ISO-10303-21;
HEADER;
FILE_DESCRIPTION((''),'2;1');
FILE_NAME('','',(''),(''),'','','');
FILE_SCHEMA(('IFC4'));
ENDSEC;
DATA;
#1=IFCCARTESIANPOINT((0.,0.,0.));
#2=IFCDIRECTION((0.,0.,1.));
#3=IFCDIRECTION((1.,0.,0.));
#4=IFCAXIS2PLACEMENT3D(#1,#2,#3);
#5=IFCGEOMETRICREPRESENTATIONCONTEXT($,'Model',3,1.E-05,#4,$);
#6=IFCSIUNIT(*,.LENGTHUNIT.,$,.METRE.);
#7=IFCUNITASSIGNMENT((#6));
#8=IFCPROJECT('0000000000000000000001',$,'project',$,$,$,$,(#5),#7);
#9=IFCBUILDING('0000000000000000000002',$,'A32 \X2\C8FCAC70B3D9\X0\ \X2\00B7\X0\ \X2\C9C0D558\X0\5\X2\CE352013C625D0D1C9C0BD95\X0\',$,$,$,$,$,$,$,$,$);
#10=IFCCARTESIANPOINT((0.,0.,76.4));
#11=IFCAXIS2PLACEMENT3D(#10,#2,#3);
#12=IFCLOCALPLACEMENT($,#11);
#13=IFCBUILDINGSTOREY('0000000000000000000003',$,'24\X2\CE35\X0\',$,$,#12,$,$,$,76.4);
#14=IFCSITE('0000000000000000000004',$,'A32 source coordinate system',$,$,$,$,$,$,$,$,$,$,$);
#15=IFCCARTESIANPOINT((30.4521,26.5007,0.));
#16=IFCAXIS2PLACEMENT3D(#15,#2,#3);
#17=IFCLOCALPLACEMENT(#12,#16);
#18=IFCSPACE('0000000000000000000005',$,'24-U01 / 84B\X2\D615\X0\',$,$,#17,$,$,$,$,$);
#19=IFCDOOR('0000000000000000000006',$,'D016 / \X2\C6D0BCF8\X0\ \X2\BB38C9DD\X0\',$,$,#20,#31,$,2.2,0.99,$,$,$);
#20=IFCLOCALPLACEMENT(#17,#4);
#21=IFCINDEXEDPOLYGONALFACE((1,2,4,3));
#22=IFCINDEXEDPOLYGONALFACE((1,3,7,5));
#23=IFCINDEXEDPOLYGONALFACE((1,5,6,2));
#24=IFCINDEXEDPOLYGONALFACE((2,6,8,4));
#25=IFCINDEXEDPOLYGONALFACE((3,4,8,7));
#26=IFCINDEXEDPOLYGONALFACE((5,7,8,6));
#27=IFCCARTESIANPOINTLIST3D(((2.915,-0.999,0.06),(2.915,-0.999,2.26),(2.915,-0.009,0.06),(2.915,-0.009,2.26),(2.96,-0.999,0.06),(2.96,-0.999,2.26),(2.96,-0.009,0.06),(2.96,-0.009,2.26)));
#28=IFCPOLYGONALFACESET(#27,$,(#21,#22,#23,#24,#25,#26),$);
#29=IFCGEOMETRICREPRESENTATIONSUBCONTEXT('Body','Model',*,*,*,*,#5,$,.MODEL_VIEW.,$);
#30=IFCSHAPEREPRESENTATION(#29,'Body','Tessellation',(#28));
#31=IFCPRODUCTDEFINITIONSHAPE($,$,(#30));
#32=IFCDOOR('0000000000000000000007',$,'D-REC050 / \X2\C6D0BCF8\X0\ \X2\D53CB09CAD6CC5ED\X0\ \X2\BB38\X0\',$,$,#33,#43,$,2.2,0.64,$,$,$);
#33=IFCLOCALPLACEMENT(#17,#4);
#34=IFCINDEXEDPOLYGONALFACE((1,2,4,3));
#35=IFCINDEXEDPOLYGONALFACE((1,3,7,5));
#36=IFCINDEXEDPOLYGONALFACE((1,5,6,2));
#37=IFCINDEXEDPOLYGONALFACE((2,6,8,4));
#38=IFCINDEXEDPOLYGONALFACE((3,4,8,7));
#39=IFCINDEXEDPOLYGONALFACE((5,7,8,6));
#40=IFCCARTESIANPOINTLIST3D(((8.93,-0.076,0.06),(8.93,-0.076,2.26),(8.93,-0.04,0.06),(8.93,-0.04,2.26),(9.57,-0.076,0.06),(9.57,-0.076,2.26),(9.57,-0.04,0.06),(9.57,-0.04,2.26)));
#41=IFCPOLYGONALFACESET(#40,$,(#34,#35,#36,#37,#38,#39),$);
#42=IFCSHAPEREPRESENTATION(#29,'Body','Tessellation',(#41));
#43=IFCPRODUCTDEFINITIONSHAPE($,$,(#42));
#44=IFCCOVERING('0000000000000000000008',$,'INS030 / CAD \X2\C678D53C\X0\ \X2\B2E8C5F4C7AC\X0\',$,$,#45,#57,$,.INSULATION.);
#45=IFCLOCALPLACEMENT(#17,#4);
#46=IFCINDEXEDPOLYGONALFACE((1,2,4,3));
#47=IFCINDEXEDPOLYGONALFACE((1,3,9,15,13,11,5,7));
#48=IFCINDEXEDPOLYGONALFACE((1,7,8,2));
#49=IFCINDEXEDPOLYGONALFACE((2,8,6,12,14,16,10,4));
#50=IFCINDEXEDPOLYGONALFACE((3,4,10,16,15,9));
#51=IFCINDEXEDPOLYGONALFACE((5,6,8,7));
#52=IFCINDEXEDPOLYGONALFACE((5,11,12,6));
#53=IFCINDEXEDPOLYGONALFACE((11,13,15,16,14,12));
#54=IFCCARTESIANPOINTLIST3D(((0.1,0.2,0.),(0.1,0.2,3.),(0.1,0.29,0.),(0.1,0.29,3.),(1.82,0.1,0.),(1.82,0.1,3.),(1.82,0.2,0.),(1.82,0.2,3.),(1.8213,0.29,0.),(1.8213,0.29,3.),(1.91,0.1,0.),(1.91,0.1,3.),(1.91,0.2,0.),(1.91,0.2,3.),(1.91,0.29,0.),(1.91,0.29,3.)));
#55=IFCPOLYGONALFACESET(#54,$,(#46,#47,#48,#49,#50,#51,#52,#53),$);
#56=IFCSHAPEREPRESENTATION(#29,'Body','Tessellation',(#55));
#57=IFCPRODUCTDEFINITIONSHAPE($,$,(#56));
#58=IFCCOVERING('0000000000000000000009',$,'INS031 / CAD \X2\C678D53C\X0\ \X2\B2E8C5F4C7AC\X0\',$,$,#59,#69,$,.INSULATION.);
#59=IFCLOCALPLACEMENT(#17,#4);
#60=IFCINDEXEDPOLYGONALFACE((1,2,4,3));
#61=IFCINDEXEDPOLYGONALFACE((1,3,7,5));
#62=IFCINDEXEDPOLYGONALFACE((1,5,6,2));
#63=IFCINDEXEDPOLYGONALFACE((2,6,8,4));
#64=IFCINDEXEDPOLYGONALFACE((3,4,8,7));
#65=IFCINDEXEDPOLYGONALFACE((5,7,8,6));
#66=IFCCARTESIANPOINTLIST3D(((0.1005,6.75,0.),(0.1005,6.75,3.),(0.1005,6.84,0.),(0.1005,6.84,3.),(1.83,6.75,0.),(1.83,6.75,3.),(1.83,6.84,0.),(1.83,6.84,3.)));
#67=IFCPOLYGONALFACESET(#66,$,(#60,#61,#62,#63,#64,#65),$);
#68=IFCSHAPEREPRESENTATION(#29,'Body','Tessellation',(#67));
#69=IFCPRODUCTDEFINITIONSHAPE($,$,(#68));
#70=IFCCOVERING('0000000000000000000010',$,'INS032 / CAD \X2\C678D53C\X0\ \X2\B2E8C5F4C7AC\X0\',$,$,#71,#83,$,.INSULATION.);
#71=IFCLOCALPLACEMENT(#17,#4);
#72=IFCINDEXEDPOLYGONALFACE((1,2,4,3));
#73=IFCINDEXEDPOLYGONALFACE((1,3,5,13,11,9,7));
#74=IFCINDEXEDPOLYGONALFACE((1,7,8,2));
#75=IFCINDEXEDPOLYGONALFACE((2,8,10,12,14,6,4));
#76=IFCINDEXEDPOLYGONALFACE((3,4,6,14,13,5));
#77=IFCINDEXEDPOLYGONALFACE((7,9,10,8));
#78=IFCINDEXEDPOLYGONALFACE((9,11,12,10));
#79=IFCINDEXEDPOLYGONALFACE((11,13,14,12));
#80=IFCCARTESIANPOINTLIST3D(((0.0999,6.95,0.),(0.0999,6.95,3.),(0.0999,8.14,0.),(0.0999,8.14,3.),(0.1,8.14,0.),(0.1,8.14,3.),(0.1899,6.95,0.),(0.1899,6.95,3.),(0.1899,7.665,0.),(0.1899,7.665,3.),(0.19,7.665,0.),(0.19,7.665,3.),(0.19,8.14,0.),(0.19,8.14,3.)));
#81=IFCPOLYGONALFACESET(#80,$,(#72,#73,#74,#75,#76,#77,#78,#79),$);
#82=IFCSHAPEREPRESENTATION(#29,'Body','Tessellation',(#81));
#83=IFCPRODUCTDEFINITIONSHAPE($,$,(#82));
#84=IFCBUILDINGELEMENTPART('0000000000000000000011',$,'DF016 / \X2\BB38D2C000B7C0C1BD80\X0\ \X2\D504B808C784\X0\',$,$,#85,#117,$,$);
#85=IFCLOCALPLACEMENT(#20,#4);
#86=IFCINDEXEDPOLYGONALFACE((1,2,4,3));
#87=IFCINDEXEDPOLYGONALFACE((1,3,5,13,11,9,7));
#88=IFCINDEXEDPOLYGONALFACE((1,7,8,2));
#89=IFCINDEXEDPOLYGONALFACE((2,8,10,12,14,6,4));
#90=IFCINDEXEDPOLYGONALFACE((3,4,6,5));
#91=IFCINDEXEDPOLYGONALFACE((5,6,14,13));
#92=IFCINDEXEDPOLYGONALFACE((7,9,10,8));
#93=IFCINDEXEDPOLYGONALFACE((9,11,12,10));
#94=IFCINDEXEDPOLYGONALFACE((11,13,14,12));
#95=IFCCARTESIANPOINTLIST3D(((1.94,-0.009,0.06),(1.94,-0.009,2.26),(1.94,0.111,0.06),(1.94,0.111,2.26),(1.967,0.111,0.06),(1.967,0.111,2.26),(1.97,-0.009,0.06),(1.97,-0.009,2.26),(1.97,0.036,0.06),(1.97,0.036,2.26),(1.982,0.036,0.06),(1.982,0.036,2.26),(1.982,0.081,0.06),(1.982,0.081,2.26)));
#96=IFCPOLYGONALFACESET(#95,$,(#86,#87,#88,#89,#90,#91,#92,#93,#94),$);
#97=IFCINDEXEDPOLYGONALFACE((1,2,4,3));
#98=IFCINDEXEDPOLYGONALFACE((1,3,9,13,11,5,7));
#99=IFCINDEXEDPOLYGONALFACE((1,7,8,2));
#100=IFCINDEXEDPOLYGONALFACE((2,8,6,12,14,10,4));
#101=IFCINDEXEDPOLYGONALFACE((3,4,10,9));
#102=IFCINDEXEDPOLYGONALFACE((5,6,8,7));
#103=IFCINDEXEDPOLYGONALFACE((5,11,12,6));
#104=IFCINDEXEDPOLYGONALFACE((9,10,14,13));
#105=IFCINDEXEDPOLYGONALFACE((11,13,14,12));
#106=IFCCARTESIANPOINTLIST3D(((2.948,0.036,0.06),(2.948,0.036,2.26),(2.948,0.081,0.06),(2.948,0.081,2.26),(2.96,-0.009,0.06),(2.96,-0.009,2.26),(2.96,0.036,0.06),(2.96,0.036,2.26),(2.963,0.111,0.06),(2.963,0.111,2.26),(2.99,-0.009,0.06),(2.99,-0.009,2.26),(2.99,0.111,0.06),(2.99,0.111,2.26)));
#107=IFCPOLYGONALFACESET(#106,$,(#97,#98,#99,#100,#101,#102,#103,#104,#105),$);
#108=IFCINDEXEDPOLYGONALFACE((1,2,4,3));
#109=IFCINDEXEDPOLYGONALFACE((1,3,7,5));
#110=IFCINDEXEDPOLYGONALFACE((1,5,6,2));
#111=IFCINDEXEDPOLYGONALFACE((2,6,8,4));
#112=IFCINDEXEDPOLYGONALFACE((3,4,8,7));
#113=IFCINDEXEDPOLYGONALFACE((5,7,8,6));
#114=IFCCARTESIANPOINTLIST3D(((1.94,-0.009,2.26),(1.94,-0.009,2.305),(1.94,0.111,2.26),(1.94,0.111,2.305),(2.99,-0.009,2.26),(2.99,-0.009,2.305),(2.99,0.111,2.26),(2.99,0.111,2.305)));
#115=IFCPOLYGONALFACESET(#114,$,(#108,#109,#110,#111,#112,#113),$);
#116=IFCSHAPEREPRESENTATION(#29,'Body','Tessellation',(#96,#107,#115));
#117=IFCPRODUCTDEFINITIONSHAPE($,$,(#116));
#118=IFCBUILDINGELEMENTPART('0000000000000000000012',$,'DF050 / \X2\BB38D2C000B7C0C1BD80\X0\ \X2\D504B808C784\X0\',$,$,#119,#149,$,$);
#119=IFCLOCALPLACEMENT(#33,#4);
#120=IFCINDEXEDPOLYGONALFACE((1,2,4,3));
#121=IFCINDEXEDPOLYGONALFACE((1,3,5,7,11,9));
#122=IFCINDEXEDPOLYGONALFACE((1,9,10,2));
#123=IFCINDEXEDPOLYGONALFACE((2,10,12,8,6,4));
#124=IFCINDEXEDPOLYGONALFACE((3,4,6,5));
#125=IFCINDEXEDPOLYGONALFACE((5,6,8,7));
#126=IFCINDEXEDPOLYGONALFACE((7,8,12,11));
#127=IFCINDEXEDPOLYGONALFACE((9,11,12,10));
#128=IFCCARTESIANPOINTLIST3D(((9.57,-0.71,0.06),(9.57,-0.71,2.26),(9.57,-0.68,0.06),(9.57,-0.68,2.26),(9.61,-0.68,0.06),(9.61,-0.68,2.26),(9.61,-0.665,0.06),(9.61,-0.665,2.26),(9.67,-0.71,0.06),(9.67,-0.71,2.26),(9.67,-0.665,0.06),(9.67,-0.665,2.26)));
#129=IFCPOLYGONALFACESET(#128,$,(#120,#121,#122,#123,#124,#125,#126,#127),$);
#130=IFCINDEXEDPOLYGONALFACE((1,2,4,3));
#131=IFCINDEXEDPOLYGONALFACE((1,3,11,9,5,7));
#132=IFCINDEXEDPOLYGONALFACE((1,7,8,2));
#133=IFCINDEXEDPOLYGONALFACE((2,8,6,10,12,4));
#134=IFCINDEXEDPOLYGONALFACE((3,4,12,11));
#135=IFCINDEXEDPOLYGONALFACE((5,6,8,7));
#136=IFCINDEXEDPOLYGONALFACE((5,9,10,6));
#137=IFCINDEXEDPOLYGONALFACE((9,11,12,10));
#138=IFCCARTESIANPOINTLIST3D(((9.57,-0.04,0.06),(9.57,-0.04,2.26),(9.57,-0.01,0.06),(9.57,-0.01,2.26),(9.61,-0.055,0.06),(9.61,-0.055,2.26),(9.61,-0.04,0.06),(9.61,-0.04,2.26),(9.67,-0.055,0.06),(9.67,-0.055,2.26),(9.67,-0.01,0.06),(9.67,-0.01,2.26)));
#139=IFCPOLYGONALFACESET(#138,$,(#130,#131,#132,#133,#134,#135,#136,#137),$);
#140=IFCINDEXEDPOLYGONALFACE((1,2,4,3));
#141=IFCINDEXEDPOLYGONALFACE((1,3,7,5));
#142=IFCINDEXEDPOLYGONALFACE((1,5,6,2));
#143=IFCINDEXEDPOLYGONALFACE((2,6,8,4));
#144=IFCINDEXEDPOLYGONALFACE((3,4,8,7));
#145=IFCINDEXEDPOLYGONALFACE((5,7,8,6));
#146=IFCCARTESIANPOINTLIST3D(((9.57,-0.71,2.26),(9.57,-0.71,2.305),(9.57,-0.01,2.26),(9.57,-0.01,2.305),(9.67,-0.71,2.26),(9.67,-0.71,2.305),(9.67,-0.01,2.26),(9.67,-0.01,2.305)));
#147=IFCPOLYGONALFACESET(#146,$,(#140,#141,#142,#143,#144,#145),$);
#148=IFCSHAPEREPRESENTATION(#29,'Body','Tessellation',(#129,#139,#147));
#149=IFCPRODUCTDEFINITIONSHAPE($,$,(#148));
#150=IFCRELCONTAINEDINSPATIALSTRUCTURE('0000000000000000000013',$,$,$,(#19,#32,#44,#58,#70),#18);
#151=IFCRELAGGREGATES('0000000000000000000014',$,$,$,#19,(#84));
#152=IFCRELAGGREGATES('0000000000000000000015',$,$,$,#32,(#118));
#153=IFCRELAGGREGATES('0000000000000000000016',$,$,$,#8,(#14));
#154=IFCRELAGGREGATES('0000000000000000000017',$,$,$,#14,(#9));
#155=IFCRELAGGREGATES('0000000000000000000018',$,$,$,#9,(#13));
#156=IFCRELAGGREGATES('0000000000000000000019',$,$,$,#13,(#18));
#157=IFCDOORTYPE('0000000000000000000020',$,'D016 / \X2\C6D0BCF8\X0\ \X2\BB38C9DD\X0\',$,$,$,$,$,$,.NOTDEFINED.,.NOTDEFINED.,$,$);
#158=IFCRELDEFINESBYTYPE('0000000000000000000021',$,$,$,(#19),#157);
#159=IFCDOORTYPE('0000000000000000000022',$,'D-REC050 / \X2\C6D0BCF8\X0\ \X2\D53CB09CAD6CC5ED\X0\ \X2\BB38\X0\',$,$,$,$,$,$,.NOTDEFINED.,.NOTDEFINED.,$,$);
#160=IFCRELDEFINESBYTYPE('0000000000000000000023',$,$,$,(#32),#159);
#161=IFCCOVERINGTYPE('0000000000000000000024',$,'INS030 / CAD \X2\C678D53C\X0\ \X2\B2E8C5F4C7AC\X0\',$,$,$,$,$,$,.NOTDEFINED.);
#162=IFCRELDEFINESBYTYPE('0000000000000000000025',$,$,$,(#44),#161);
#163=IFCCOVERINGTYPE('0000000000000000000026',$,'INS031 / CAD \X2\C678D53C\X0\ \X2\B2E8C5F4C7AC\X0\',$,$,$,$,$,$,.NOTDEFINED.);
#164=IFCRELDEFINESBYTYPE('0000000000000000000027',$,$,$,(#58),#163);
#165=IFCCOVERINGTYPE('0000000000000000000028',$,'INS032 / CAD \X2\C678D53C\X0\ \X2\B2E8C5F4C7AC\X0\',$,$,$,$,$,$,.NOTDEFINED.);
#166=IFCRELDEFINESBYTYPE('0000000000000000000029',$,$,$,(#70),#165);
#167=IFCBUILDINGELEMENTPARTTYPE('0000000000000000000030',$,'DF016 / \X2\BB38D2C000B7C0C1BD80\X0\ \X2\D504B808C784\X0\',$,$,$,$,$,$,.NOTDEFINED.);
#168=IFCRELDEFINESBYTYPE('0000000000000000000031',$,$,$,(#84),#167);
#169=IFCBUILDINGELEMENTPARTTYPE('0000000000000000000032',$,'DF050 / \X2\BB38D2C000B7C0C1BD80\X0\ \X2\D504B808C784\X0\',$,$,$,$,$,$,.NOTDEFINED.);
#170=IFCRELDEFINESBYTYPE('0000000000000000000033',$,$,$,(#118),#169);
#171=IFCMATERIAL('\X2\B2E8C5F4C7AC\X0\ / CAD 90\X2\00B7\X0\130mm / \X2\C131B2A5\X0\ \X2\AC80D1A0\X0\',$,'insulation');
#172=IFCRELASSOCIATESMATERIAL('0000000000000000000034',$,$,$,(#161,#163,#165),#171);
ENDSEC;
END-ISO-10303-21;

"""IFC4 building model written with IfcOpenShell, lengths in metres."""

from ifc_helpers import new_model, si_unit, frame, origin, origin_with_axes, place, context, subcontext, project, spatial, polyline, outline, extrude, source, transform, mapped, material, type_object, type_shapes, element, aggregate, save


model = new_model("IFC4")

# Units and contexts
model_context = context("Model", 3, precision=1e-05, world=origin_with_axes())
body_context = subcontext(model_context, "Body", "Model", "MODEL_VIEW")
ifc_project = project(units=[si_unit("LENGTHUNIT", "METRE")], contexts=[model_context])

# Site, building, storey, space
storey_placement = place(None, frame((0.0, 0.0, 76.4), z_axis=(0.0, 0.0, 1.0), x_axis=(1.0, 0.0, 0.0)))
space_placement = place(storey_placement, frame((30.4521, 26.5007, 0.0), z_axis=(0.0, 0.0, 1.0), x_axis=(1.0, 0.0, 0.0)))
site = spatial("IfcSite", under=ifc_project, Name="A32 source coordinate system")
building = spatial("IfcBuilding", under=site, Name="A32 주거동 · 지하5층–옥탑지붕")
storey = spatial("IfcBuildingStorey", under=building, at=storey_placement, Name="24층", Elevation=76.4)
space = spatial("IfcSpace", under=storey, at=space_placement, Name="24-U01 / 84B형")

# Doors
door_type_1 = type_object("IfcDoorType", Name="D016 / 원본 문짝", OperationType="NOTDEFINED", PredefinedType="NOTDEFINED")
shared_shape_1 = source(origin(), body_context, "Body", "SweptSolid", [
    extrude(outline(polyline([(2.96, -0.009), (2.96, -0.999), (2.915, -0.999), (2.915, -0.009), (2.96, -0.009)])), frame((0.0, 0.0, 0.06)), (0.0, 0.0, 1.0), 2.2),
])
type_shapes(door_type_1, [shared_shape_1])
door_1_placement = place(space_placement, origin_with_axes())
door_1 = element("IfcDoor", 1, at=door_1_placement, inside=space, type_object=door_type_1, Name="D016 / 원본 문짝", OverallHeight=2.2, OverallWidth=0.99, context=body_context, shape_type="MappedRepresentation", body=[
    mapped(shared_shape_1, transform((0.0, 0.0, 0.0), scale=1.0)),
])
door_type_2 = type_object("IfcDoorType", Name="D-REC050 / 원본 피난구역 문", OperationType="NOTDEFINED", PredefinedType="NOTDEFINED")
shared_shape_2 = source(origin(), body_context, "Body", "SweptSolid", [
    extrude(outline(polyline([(9.57, -0.04), (9.57, -0.076), (8.93, -0.076), (8.93, -0.04), (9.57, -0.04)])), frame((0.0, 0.0, 0.06)), (0.0, 0.0, 1.0), 2.2),
])
type_shapes(door_type_2, [shared_shape_2])
door_2_placement = place(space_placement, origin_with_axes())
door_2 = element("IfcDoor", 2, at=door_2_placement, inside=space, type_object=door_type_2, Name="D-REC050 / 원본 피난구역 문", OverallHeight=2.2, OverallWidth=0.64, context=body_context, shape_type="MappedRepresentation", body=[
    mapped(shared_shape_2, transform((0.0, 0.0, 0.0), scale=1.0)),
])

# Coverings
ifc_material = material(Name="단열재 / CAD 90·130mm / 성능 검토", Category="insulation")
covering_type_1 = type_object("IfcCoveringType", Name="INS030 / CAD 외피 단열재", PredefinedType="NOTDEFINED", material=ifc_material)
shared_shape_3 = source(origin(), body_context, "Body", "SweptSolid", [
    extrude(outline(polyline([(1.91, 0.2), (1.91, 0.1), (1.82, 0.1), (1.82, 0.2), (0.1, 0.2), (0.1, 0.29), (1.8213, 0.29), (1.91, 0.29), (1.91, 0.2)])), origin(), (0.0, 0.0, 1.0), 3.0),
])
type_shapes(covering_type_1, [shared_shape_3])
covering_1_placement = place(space_placement, origin_with_axes())
element("IfcCovering", 3, at=covering_1_placement, inside=space, type_object=covering_type_1, Name="INS030 / CAD 외피 단열재", PredefinedType="INSULATION", context=body_context, shape_type="MappedRepresentation", body=[
    mapped(shared_shape_3, transform((0.0, 0.0, 0.0), scale=1.0)),
])
covering_type_2 = type_object("IfcCoveringType", Name="INS031 / CAD 외피 단열재", PredefinedType="NOTDEFINED", material=ifc_material)
shared_shape_4 = source(origin(), body_context, "Body", "SweptSolid", [
    extrude(outline(polyline([(1.83, 6.75), (0.1005, 6.75), (0.1005, 6.84), (1.83, 6.84), (1.83, 6.75)])), origin(), (0.0, 0.0, 1.0), 3.0),
])
type_shapes(covering_type_2, [shared_shape_4])
covering_2_placement = place(space_placement, origin_with_axes())
element("IfcCovering", 4, at=covering_2_placement, inside=space, type_object=covering_type_2, Name="INS031 / CAD 외피 단열재", PredefinedType="INSULATION", context=body_context, shape_type="MappedRepresentation", body=[
    mapped(shared_shape_4, transform((0.0, 0.0, 0.0), scale=1.0)),
])
covering_type_3 = type_object("IfcCoveringType", Name="INS032 / CAD 외피 단열재", PredefinedType="NOTDEFINED", material=ifc_material)
shared_shape_5 = source(origin(), body_context, "Body", "SweptSolid", [
    extrude(outline(polyline([(0.1899, 6.95), (0.0999, 6.95), (0.0999, 8.14), (0.1, 8.14), (0.19, 8.14), (0.19, 7.665), (0.1899, 7.665), (0.1899, 6.95)])), origin(), (0.0, 0.0, 1.0), 3.0),
])
type_shapes(covering_type_3, [shared_shape_5])
covering_3_placement = place(space_placement, origin_with_axes())
element("IfcCovering", 5, at=covering_3_placement, inside=space, type_object=covering_type_3, Name="INS032 / CAD 외피 단열재", PredefinedType="INSULATION", context=body_context, shape_type="MappedRepresentation", body=[
    mapped(shared_shape_5, transform((0.0, 0.0, 0.0), scale=1.0)),
])

# Building element parts
building_element_part_type_1 = type_object("IfcBuildingElementPartType", Name="DF016 / 문틀·상부 프레임", PredefinedType="NOTDEFINED")
shared_shape_6 = source(origin(), body_context, "Body", "SweptSolid", [
    extrude(outline(polyline([(1.94, 0.111), (1.967, 0.111), (1.982, 0.081), (1.982, 0.036), (1.97, 0.036), (1.97, -0.009), (1.94, -0.009), (1.94, 0.111)])), frame((0.0, 0.0, 0.06)), (0.0, 0.0, 1.0), 2.2),
    extrude(outline(polyline([(2.96, -0.009), (2.96, 0.036), (2.948, 0.036), (2.948, 0.081), (2.963, 0.111), (2.99, 0.111), (2.99, -0.009), (2.96, -0.009)])), frame((0.0, 0.0, 0.06)), (0.0, 0.0, 1.0), 2.2),
    extrude(outline(polyline([(1.94, -0.009), (1.94, 0.111), (2.99, 0.111), (2.99, -0.009), (1.94, -0.009)])), frame((0.0, 0.0, 2.26)), (0.0, 0.0, 1.0), 0.045),
])
type_shapes(building_element_part_type_1, [shared_shape_6])
building_element_part_1_placement = place(door_1_placement, origin_with_axes())
building_element_part_1 = element("IfcBuildingElementPart", 6, at=building_element_part_1_placement, type_object=building_element_part_type_1, Name="DF016 / 문틀·상부 프레임", context=body_context, shape_type="MappedRepresentation", body=[
    mapped(shared_shape_6, transform((0.0, 0.0, 0.0), scale=1.0)),
])
aggregate(door_1, [building_element_part_1])
building_element_part_type_2 = type_object("IfcBuildingElementPartType", Name="DF050 / 문틀·상부 프레임", PredefinedType="NOTDEFINED")
shared_shape_7 = source(origin(), body_context, "Body", "SweptSolid", [
    extrude(outline(polyline([(9.57, -0.68), (9.61, -0.68), (9.61, -0.665), (9.67, -0.665), (9.67, -0.71), (9.57, -0.71), (9.57, -0.68)])), frame((0.0, 0.0, 0.06)), (0.0, 0.0, 1.0), 2.2),
    extrude(outline(polyline([(9.67, -0.01), (9.67, -0.055), (9.61, -0.055), (9.61, -0.04), (9.57, -0.04), (9.57, -0.01), (9.67, -0.01)])), frame((0.0, 0.0, 0.06)), (0.0, 0.0, 1.0), 2.2),
    extrude(outline(polyline([(9.57, -0.71), (9.57, -0.01), (9.67, -0.01), (9.67, -0.71), (9.57, -0.71)])), frame((0.0, 0.0, 2.26)), (0.0, 0.0, 1.0), 0.045),
])
type_shapes(building_element_part_type_2, [shared_shape_7])
building_element_part_2_placement = place(door_2_placement, origin_with_axes())
building_element_part_2 = element("IfcBuildingElementPart", 7, at=building_element_part_2_placement, type_object=building_element_part_type_2, Name="DF050 / 문틀·상부 프레임", context=body_context, shape_type="MappedRepresentation", body=[
    mapped(shared_shape_7, transform((0.0, 0.0, 0.0), scale=1.0)),
])
aggregate(door_2, [building_element_part_2])

save(model, "model.ifc")
